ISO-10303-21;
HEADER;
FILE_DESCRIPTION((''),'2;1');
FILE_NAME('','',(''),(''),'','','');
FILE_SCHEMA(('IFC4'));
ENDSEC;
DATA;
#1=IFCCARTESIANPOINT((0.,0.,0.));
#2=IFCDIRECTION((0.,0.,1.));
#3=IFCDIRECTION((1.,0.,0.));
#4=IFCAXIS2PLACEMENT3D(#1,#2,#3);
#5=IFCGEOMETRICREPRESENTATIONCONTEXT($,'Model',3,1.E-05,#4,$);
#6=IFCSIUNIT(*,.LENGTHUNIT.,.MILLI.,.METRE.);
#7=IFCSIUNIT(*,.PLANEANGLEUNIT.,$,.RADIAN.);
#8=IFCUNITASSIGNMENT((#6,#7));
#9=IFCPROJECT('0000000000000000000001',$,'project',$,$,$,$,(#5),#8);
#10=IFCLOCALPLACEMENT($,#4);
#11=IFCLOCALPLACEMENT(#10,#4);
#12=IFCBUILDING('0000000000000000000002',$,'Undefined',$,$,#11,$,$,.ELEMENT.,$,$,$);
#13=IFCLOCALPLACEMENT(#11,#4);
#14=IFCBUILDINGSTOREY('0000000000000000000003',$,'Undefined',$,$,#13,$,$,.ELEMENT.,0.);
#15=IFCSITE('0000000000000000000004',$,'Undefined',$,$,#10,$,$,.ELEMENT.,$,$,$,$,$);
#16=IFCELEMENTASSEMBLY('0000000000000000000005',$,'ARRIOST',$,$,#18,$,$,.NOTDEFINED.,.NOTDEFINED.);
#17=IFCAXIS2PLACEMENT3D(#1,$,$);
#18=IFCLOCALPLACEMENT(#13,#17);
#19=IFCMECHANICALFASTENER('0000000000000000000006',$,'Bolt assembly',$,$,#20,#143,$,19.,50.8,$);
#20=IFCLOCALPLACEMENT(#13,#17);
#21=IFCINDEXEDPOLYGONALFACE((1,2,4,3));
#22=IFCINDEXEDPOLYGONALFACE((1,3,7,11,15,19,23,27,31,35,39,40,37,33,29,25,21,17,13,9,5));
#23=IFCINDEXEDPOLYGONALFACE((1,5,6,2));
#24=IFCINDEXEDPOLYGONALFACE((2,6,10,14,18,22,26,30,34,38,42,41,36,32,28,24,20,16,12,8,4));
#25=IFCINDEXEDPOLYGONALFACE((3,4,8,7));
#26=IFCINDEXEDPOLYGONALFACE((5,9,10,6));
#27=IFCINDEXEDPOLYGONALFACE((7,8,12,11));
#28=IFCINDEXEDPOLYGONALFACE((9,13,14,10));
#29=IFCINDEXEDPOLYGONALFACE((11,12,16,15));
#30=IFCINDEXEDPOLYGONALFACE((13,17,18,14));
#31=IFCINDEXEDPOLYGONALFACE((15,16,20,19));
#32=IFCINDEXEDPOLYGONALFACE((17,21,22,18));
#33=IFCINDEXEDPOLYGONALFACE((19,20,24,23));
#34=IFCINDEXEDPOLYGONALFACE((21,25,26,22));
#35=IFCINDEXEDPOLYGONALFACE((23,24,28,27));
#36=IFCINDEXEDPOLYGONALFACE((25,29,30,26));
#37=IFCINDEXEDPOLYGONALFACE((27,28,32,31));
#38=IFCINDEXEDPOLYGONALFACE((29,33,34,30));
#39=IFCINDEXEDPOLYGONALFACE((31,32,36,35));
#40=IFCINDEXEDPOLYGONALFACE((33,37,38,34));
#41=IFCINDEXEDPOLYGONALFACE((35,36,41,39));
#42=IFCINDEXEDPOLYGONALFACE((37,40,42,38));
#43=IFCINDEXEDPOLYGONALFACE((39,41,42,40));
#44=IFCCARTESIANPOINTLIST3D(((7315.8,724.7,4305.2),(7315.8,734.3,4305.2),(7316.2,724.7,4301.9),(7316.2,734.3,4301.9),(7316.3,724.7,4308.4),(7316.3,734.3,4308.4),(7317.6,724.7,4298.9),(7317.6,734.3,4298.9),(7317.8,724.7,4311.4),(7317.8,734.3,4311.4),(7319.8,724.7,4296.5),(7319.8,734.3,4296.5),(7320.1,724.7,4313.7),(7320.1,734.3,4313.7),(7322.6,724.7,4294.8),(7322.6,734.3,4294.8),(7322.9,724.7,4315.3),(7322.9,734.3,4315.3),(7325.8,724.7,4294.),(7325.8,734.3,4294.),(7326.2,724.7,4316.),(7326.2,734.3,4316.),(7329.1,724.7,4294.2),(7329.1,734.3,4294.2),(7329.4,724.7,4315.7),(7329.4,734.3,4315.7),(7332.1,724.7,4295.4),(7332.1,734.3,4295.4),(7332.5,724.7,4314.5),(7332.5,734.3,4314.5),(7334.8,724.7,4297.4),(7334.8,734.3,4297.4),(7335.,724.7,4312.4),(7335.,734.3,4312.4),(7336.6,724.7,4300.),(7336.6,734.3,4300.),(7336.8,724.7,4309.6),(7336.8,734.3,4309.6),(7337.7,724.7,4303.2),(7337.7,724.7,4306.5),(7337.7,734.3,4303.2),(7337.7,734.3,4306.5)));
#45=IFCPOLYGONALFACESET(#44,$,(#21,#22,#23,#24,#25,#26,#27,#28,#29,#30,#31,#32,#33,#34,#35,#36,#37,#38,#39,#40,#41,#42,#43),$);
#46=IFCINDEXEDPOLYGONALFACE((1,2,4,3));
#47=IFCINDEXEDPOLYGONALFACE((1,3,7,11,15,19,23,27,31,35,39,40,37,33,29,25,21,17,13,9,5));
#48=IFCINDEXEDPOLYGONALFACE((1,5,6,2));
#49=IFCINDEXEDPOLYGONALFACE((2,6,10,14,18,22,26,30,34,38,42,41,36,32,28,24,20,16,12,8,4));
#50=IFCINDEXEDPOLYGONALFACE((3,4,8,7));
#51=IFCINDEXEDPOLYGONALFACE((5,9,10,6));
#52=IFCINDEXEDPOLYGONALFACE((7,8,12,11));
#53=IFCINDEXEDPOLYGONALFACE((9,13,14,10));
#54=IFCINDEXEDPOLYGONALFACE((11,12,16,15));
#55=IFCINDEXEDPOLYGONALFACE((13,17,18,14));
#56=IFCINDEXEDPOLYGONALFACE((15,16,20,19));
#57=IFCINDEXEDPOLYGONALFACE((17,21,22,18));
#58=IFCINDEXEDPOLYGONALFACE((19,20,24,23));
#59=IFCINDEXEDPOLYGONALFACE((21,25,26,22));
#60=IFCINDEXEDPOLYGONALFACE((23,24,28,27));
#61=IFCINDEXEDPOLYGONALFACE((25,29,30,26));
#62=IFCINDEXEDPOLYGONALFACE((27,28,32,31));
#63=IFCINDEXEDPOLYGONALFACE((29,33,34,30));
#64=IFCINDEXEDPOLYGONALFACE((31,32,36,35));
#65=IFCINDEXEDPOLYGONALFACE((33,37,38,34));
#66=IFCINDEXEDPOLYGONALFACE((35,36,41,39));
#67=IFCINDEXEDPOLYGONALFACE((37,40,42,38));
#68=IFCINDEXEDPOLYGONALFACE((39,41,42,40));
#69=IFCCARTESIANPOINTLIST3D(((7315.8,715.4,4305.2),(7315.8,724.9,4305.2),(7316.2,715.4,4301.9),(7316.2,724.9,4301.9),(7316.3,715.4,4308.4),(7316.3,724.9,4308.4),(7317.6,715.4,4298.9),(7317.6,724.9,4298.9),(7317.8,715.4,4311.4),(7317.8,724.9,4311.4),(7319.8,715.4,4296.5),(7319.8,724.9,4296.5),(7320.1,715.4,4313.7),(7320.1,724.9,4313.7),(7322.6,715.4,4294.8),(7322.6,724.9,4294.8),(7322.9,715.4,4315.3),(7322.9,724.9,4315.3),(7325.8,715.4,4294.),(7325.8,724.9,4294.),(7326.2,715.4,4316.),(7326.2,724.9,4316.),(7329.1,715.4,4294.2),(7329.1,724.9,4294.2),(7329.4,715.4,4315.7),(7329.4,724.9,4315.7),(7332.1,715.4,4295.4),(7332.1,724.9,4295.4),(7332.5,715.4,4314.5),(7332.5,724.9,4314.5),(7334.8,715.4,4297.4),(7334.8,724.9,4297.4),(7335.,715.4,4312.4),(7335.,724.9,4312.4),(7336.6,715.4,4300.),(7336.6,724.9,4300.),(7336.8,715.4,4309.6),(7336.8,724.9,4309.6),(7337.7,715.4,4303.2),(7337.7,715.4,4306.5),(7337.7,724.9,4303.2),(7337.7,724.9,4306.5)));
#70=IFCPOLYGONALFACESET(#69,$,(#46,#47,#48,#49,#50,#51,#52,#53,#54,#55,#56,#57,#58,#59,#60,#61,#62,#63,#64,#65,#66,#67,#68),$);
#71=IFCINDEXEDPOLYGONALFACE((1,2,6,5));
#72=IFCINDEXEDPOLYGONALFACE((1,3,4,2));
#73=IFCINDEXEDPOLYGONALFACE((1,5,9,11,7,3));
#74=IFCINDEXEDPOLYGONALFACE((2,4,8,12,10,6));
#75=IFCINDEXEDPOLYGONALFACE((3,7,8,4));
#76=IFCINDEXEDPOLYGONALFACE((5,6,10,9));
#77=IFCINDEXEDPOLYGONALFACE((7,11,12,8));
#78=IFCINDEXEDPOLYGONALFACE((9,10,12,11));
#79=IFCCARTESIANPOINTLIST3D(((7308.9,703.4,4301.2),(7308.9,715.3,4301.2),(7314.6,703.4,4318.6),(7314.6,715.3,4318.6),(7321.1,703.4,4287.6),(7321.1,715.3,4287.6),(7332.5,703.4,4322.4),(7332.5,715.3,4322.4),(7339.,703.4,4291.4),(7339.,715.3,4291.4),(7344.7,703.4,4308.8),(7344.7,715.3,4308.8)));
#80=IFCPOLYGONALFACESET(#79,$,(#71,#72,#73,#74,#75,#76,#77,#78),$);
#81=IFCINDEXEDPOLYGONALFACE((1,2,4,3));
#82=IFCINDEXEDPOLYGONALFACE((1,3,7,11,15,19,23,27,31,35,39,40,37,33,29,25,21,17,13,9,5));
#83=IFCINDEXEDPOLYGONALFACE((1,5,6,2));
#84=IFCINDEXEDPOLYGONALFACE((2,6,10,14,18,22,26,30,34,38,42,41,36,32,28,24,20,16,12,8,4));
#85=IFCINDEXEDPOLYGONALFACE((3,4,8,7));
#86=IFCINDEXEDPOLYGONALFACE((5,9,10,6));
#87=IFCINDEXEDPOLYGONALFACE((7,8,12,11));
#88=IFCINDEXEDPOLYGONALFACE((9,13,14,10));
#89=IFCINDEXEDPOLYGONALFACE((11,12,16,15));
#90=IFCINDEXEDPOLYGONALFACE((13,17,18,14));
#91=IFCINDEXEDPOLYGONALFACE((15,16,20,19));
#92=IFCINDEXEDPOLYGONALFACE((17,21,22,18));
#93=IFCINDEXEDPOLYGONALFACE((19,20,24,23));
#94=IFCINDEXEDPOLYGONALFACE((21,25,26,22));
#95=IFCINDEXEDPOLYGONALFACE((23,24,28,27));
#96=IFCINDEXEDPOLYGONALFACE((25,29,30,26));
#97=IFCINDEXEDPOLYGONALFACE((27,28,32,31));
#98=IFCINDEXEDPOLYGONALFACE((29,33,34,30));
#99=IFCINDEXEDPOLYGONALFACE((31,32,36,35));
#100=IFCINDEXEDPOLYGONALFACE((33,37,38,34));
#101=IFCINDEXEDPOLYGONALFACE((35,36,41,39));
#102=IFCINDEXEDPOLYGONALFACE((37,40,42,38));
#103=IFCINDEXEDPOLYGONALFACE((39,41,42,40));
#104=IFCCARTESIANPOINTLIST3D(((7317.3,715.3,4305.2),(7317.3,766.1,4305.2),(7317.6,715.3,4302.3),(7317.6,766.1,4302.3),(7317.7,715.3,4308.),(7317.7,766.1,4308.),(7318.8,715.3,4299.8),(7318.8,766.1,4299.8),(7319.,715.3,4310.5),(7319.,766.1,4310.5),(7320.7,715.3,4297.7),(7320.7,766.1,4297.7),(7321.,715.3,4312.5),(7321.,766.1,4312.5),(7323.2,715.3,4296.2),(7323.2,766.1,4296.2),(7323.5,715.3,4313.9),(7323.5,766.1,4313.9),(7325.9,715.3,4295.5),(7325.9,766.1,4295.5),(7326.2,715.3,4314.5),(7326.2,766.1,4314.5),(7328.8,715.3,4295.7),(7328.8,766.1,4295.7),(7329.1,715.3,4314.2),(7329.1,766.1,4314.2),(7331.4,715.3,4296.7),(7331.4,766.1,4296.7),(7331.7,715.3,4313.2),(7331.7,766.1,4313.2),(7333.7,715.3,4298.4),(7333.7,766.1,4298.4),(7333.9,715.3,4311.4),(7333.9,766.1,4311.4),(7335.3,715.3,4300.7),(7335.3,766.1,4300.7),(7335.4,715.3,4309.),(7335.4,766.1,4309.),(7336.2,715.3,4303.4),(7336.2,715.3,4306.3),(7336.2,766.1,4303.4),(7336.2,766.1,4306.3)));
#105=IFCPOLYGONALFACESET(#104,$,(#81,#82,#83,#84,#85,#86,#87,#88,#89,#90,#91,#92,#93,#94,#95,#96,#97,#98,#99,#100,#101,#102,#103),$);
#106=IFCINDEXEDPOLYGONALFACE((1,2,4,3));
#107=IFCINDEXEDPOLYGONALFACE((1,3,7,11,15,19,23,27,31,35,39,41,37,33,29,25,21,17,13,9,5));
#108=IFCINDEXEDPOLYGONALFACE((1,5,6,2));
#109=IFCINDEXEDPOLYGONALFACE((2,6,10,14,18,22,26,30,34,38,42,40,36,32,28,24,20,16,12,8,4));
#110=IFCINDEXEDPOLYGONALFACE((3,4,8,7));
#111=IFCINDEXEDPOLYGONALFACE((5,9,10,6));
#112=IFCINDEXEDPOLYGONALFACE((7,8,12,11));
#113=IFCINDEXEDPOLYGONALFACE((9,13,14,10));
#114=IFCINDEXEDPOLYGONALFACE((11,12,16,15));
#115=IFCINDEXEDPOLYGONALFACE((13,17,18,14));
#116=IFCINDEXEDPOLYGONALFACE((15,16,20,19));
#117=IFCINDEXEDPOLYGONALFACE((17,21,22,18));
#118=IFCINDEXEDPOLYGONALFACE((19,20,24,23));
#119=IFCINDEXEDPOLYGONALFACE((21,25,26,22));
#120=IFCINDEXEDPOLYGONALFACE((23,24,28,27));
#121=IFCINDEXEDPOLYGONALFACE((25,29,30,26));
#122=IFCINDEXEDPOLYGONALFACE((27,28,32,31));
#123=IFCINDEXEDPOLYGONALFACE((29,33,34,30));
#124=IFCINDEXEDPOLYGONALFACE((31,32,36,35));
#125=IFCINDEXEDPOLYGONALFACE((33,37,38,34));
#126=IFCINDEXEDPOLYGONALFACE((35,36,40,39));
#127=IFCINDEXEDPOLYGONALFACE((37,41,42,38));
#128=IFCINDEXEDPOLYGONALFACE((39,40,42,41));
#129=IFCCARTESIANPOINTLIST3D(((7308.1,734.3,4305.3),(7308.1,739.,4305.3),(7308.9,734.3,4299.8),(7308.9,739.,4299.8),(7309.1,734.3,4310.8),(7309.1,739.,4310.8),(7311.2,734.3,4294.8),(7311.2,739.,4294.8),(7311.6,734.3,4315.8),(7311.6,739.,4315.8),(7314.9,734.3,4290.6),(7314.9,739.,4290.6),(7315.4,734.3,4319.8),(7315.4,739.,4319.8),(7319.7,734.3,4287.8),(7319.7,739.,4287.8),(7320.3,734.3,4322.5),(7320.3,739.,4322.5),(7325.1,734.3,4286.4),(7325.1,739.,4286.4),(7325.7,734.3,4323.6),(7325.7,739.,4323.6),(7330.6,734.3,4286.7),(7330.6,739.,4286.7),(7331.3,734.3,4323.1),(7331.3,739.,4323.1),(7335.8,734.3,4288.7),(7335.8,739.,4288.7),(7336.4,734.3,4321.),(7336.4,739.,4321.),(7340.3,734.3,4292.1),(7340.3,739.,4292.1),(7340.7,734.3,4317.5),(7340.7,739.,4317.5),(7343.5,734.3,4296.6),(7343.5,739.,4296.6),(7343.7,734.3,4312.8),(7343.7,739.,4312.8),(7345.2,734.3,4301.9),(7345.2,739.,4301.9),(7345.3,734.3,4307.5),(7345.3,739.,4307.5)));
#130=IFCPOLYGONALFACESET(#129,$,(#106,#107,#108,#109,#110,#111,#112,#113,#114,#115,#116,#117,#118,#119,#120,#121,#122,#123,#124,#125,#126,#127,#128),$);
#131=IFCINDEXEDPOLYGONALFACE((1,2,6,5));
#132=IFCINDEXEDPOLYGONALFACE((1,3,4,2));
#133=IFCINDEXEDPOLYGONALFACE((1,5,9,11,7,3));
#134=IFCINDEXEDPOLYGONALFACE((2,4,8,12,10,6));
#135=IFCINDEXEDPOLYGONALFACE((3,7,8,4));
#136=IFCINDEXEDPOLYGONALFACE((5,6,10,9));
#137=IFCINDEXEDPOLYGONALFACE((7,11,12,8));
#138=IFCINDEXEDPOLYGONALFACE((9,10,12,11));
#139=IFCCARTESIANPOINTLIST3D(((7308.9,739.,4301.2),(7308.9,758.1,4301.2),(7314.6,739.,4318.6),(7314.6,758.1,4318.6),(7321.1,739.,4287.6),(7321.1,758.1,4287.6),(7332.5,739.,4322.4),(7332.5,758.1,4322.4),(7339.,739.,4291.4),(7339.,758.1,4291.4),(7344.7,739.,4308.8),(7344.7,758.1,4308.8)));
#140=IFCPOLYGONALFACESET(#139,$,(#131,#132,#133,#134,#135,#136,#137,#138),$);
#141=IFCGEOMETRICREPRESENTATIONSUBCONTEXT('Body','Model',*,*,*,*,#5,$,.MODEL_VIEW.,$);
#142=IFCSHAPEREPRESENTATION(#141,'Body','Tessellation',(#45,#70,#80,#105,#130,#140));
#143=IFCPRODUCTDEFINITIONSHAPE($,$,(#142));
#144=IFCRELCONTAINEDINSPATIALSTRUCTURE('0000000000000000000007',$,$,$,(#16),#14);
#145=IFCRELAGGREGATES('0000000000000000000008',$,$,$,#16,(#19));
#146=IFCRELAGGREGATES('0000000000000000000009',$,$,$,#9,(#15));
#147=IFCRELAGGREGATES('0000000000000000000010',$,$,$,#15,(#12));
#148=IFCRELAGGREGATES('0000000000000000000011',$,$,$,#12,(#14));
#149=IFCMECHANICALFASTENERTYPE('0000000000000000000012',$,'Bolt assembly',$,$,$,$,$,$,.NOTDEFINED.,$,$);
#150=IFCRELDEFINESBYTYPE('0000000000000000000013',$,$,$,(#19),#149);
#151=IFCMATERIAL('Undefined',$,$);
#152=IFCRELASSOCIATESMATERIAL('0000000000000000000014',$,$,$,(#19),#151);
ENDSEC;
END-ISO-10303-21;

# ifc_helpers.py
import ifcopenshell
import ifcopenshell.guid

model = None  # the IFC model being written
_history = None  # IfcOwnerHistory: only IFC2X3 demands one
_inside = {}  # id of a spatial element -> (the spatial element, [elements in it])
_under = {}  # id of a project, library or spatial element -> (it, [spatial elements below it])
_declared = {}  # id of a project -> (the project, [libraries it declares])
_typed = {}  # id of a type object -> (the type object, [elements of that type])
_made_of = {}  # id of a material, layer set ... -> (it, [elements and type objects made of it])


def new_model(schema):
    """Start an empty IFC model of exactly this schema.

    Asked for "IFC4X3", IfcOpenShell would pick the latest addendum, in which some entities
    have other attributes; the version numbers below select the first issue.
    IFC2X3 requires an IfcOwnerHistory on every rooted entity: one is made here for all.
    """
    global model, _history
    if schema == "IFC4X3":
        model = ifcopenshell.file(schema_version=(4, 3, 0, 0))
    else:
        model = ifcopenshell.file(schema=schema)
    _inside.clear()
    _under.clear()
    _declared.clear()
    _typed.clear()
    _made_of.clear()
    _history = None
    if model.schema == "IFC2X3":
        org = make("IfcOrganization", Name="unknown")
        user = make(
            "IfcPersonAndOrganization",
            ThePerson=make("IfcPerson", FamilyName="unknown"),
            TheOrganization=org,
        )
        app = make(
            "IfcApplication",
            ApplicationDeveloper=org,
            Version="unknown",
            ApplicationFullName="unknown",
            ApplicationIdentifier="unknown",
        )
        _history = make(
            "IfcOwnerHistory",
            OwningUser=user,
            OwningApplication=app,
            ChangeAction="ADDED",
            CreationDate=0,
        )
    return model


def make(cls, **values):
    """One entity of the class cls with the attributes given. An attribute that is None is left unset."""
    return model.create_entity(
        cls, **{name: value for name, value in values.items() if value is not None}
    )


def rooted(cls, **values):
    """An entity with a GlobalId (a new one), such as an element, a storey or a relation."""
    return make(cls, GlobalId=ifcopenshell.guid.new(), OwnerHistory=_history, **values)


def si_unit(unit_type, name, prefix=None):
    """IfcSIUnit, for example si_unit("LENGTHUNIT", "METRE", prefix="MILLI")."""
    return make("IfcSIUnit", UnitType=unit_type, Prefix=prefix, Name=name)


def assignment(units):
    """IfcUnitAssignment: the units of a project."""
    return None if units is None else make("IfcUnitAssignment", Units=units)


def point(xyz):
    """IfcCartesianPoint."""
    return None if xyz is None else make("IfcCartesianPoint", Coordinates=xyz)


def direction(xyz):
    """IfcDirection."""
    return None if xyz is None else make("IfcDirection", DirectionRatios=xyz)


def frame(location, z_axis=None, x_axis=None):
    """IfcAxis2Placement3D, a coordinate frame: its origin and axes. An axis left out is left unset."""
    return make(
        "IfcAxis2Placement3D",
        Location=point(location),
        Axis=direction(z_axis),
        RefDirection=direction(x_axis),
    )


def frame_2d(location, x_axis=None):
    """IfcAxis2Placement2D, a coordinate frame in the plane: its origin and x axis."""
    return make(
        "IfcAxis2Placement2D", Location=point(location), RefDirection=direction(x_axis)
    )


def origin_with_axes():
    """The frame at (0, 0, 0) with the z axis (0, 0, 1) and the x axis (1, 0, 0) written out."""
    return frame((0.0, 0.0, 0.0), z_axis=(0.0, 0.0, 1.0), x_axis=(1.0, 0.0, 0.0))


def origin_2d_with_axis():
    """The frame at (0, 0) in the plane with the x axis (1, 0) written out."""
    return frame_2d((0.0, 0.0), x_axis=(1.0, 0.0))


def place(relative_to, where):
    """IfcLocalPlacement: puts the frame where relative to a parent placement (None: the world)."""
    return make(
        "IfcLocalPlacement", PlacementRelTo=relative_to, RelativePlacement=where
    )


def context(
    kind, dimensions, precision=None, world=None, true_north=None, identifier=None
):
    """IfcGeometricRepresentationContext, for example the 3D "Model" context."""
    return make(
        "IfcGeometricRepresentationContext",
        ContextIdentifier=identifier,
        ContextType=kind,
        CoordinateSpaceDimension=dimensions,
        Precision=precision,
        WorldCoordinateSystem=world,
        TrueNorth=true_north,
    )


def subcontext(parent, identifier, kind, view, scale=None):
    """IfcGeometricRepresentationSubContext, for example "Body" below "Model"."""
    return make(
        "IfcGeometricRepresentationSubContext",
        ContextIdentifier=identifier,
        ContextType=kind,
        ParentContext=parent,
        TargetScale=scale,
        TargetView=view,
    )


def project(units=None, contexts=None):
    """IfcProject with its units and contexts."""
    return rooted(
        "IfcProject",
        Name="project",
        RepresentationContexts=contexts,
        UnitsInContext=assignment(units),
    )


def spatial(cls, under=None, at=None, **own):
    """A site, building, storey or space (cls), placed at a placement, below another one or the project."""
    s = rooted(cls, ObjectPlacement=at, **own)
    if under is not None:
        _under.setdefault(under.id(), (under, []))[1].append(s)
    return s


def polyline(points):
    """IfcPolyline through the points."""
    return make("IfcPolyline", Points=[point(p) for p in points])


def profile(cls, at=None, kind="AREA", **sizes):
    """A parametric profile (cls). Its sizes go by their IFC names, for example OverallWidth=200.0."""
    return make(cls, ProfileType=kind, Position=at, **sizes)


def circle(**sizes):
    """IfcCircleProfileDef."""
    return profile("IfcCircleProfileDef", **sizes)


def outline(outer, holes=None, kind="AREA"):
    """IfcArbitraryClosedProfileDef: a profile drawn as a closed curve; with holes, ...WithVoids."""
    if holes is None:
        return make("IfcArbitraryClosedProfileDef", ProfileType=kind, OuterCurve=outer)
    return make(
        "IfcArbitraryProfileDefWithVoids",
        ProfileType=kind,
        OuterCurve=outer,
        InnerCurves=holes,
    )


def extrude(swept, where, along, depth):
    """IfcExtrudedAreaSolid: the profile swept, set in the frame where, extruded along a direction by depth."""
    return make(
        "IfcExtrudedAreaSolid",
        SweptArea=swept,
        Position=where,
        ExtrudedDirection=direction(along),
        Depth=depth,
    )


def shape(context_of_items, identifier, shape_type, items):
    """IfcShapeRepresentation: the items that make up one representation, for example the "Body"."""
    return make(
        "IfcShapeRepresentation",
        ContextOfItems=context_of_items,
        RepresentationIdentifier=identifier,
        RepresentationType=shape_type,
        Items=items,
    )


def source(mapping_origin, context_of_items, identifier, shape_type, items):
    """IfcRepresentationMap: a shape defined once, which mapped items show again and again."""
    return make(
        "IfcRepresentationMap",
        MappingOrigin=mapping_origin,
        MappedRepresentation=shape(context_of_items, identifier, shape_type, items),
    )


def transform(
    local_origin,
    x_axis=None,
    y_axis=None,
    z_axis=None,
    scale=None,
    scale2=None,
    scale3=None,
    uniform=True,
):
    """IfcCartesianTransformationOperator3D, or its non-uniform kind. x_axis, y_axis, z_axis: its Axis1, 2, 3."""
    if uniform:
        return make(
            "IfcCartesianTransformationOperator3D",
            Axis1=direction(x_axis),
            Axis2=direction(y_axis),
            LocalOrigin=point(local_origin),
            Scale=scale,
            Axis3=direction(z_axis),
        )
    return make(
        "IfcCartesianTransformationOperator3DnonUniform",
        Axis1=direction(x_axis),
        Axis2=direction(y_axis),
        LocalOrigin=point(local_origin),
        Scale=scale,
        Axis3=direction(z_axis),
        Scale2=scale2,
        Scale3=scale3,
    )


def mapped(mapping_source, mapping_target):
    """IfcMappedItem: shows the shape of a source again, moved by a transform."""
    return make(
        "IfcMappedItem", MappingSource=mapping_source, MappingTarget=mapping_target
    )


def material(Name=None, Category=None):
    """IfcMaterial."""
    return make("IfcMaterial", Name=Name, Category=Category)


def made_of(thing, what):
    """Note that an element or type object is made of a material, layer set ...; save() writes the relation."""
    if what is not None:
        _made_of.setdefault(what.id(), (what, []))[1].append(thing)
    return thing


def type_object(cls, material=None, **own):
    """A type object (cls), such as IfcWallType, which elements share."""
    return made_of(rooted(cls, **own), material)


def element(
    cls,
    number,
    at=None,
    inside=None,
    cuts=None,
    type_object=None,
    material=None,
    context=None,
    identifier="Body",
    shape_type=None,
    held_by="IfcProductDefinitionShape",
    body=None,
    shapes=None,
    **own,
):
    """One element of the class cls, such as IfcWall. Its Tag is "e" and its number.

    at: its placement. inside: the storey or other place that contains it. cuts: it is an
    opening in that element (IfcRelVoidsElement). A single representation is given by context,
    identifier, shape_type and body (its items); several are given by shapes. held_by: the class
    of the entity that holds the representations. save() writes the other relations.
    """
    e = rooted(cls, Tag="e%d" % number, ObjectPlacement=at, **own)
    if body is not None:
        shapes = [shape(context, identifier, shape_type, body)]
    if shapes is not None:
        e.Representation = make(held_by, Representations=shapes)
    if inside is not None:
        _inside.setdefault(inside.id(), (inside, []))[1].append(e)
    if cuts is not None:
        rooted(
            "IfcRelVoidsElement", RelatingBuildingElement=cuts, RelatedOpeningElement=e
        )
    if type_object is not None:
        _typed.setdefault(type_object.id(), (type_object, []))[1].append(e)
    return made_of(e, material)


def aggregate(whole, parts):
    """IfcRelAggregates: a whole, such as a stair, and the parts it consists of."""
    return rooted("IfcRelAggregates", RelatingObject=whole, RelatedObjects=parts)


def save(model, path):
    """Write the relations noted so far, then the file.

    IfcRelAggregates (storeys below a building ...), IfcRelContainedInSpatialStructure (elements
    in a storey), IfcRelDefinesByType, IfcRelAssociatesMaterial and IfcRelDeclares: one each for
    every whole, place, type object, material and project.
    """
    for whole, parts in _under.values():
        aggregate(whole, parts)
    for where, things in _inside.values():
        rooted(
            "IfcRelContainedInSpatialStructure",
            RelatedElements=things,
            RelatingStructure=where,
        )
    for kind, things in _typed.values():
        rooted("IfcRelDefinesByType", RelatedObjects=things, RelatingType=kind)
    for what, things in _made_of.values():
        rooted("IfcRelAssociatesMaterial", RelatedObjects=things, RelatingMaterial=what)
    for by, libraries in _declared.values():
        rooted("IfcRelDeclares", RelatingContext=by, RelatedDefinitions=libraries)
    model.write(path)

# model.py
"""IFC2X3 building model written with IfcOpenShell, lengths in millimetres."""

from ifc_helpers import new_model, si_unit, frame, origin_with_axes, origin_2d_with_axis, place, context, subcontext, project, spatial, polyline, circle, outline, extrude, source, transform, mapped, material, type_object, element, aggregate, save


model = new_model("IFC2X3")

# Units and contexts
model_context = context("Model", 3, precision=1e-05, world=origin_with_axes())
body_context = subcontext(model_context, "Body", "Model", "MODEL_VIEW")
ifc_project = project(units=[si_unit("LENGTHUNIT", "METRE", prefix="MILLI"), si_unit("PLANEANGLEUNIT", "RADIAN")], contexts=[model_context])

# Site, building, storey
site_placement = place(None, origin_with_axes())
site = spatial("IfcSite", under=ifc_project, at=site_placement, Name="Undefined", CompositionType="ELEMENT")
building_placement = place(site_placement, origin_with_axes())
building = spatial("IfcBuilding", under=site, at=building_placement, Name="Undefined", CompositionType="ELEMENT")
storey_placement = place(building_placement, origin_with_axes())
storey = spatial("IfcBuildingStorey", under=building, at=storey_placement, Name="Undefined", CompositionType="ELEMENT", Elevation=0.0)

# Element assembly
assembly_1_placement = place(storey_placement, origin_with_axes())
assembly_1 = element("IfcElementAssembly", 1, at=assembly_1_placement, inside=storey, Name="ARRIOST", AssemblyPlace="NOTDEFINED", PredefinedType="NOTDEFINED")

# Shared definitions
ifc_material_1 = material(Name="Undefined")
mechanical_fastener_type = type_object("IfcMechanicalFastenerType", Name="Bolt assembly")

# Mechanical fastener
shared_shape_1 = source(origin_with_axes(), body_context, "Body", "SweptSolid", [
    extrude(circle(Radius=11.0, at=origin_2d_with_axis()), frame((0.0, 4.6, 0.0), z_axis=(0.0, 1.0, 0.0), x_axis=(1.0, 0.0, 0.0)), (0.0, 0.0, 1.0), 9.6),
    extrude(circle(Radius=11.0, at=origin_2d_with_axis()), frame((0.0, -4.6, 0.0), z_axis=(0.0, 1.0, 0.0), x_axis=(1.0, 0.0, 0.0)), (0.0, 0.0, 1.0), 9.5),
    extrude(outline(polyline([(15.9, -9.2), (15.9, 9.2), (0.0, 18.3), (-15.9, 9.2), (-15.9, -9.2), (0.0, -18.3), (15.9, -9.2)])), frame((0.0, -16.7, 0.0), z_axis=(0.0, 1.0, 0.0), x_axis=(1.0, 0.0, 0.0)), (0.0, 0.0, 1.0), 11.9),
    extrude(circle(Radius=9.5, at=origin_2d_with_axis()), frame((0.0, -4.7, 0.0), z_axis=(0.0, 1.0, 0.0), x_axis=(1.0, 0.0, 0.0)), (0.0, 0.0, 1.0), 50.8),
    extrude(circle(Radius=18.7, at=origin_2d_with_axis()), frame((0.0, 14.2, 0.0), z_axis=(0.0, 1.0, 0.0), x_axis=(1.0, 0.0, 0.0)), (0.0, 0.0, 1.0), 4.8),
    extrude(outline(polyline([(15.9, -9.2), (15.9, 9.2), (0.0, 18.3), (-15.9, 9.2), (-15.9, -9.2), (0.0, -18.3), (15.9, -9.2)])), frame((0.0, 19.0, 0.0), z_axis=(0.0, 1.0, 0.0), x_axis=(1.0, 0.0, 0.0)), (0.0, 0.0, 1.0), 19.1),
])
mechanical_fastener_1_placement = place(assembly_1_placement, frame((7326.8, 720.0, 4305.0), z_axis=(-0.310823, 0.000007, -0.950468), x_axis=(-0.950468, -0.000002, 0.310823)))
mechanical_fastener_1 = element("IfcMechanicalFastener", 2, at=mechanical_fastener_1_placement, type_object=mechanical_fastener_type, material=ifc_material_1, Name="Bolt assembly", NominalDiameter=19.0, NominalLength=50.8, context=body_context, shape_type="MappedRepresentation", body=[
    mapped(shared_shape_1, transform((0.0, 0.0, 0.0))),
])
aggregate(assembly_1, [mechanical_fastener_1])

save(model, "model.ifc")
